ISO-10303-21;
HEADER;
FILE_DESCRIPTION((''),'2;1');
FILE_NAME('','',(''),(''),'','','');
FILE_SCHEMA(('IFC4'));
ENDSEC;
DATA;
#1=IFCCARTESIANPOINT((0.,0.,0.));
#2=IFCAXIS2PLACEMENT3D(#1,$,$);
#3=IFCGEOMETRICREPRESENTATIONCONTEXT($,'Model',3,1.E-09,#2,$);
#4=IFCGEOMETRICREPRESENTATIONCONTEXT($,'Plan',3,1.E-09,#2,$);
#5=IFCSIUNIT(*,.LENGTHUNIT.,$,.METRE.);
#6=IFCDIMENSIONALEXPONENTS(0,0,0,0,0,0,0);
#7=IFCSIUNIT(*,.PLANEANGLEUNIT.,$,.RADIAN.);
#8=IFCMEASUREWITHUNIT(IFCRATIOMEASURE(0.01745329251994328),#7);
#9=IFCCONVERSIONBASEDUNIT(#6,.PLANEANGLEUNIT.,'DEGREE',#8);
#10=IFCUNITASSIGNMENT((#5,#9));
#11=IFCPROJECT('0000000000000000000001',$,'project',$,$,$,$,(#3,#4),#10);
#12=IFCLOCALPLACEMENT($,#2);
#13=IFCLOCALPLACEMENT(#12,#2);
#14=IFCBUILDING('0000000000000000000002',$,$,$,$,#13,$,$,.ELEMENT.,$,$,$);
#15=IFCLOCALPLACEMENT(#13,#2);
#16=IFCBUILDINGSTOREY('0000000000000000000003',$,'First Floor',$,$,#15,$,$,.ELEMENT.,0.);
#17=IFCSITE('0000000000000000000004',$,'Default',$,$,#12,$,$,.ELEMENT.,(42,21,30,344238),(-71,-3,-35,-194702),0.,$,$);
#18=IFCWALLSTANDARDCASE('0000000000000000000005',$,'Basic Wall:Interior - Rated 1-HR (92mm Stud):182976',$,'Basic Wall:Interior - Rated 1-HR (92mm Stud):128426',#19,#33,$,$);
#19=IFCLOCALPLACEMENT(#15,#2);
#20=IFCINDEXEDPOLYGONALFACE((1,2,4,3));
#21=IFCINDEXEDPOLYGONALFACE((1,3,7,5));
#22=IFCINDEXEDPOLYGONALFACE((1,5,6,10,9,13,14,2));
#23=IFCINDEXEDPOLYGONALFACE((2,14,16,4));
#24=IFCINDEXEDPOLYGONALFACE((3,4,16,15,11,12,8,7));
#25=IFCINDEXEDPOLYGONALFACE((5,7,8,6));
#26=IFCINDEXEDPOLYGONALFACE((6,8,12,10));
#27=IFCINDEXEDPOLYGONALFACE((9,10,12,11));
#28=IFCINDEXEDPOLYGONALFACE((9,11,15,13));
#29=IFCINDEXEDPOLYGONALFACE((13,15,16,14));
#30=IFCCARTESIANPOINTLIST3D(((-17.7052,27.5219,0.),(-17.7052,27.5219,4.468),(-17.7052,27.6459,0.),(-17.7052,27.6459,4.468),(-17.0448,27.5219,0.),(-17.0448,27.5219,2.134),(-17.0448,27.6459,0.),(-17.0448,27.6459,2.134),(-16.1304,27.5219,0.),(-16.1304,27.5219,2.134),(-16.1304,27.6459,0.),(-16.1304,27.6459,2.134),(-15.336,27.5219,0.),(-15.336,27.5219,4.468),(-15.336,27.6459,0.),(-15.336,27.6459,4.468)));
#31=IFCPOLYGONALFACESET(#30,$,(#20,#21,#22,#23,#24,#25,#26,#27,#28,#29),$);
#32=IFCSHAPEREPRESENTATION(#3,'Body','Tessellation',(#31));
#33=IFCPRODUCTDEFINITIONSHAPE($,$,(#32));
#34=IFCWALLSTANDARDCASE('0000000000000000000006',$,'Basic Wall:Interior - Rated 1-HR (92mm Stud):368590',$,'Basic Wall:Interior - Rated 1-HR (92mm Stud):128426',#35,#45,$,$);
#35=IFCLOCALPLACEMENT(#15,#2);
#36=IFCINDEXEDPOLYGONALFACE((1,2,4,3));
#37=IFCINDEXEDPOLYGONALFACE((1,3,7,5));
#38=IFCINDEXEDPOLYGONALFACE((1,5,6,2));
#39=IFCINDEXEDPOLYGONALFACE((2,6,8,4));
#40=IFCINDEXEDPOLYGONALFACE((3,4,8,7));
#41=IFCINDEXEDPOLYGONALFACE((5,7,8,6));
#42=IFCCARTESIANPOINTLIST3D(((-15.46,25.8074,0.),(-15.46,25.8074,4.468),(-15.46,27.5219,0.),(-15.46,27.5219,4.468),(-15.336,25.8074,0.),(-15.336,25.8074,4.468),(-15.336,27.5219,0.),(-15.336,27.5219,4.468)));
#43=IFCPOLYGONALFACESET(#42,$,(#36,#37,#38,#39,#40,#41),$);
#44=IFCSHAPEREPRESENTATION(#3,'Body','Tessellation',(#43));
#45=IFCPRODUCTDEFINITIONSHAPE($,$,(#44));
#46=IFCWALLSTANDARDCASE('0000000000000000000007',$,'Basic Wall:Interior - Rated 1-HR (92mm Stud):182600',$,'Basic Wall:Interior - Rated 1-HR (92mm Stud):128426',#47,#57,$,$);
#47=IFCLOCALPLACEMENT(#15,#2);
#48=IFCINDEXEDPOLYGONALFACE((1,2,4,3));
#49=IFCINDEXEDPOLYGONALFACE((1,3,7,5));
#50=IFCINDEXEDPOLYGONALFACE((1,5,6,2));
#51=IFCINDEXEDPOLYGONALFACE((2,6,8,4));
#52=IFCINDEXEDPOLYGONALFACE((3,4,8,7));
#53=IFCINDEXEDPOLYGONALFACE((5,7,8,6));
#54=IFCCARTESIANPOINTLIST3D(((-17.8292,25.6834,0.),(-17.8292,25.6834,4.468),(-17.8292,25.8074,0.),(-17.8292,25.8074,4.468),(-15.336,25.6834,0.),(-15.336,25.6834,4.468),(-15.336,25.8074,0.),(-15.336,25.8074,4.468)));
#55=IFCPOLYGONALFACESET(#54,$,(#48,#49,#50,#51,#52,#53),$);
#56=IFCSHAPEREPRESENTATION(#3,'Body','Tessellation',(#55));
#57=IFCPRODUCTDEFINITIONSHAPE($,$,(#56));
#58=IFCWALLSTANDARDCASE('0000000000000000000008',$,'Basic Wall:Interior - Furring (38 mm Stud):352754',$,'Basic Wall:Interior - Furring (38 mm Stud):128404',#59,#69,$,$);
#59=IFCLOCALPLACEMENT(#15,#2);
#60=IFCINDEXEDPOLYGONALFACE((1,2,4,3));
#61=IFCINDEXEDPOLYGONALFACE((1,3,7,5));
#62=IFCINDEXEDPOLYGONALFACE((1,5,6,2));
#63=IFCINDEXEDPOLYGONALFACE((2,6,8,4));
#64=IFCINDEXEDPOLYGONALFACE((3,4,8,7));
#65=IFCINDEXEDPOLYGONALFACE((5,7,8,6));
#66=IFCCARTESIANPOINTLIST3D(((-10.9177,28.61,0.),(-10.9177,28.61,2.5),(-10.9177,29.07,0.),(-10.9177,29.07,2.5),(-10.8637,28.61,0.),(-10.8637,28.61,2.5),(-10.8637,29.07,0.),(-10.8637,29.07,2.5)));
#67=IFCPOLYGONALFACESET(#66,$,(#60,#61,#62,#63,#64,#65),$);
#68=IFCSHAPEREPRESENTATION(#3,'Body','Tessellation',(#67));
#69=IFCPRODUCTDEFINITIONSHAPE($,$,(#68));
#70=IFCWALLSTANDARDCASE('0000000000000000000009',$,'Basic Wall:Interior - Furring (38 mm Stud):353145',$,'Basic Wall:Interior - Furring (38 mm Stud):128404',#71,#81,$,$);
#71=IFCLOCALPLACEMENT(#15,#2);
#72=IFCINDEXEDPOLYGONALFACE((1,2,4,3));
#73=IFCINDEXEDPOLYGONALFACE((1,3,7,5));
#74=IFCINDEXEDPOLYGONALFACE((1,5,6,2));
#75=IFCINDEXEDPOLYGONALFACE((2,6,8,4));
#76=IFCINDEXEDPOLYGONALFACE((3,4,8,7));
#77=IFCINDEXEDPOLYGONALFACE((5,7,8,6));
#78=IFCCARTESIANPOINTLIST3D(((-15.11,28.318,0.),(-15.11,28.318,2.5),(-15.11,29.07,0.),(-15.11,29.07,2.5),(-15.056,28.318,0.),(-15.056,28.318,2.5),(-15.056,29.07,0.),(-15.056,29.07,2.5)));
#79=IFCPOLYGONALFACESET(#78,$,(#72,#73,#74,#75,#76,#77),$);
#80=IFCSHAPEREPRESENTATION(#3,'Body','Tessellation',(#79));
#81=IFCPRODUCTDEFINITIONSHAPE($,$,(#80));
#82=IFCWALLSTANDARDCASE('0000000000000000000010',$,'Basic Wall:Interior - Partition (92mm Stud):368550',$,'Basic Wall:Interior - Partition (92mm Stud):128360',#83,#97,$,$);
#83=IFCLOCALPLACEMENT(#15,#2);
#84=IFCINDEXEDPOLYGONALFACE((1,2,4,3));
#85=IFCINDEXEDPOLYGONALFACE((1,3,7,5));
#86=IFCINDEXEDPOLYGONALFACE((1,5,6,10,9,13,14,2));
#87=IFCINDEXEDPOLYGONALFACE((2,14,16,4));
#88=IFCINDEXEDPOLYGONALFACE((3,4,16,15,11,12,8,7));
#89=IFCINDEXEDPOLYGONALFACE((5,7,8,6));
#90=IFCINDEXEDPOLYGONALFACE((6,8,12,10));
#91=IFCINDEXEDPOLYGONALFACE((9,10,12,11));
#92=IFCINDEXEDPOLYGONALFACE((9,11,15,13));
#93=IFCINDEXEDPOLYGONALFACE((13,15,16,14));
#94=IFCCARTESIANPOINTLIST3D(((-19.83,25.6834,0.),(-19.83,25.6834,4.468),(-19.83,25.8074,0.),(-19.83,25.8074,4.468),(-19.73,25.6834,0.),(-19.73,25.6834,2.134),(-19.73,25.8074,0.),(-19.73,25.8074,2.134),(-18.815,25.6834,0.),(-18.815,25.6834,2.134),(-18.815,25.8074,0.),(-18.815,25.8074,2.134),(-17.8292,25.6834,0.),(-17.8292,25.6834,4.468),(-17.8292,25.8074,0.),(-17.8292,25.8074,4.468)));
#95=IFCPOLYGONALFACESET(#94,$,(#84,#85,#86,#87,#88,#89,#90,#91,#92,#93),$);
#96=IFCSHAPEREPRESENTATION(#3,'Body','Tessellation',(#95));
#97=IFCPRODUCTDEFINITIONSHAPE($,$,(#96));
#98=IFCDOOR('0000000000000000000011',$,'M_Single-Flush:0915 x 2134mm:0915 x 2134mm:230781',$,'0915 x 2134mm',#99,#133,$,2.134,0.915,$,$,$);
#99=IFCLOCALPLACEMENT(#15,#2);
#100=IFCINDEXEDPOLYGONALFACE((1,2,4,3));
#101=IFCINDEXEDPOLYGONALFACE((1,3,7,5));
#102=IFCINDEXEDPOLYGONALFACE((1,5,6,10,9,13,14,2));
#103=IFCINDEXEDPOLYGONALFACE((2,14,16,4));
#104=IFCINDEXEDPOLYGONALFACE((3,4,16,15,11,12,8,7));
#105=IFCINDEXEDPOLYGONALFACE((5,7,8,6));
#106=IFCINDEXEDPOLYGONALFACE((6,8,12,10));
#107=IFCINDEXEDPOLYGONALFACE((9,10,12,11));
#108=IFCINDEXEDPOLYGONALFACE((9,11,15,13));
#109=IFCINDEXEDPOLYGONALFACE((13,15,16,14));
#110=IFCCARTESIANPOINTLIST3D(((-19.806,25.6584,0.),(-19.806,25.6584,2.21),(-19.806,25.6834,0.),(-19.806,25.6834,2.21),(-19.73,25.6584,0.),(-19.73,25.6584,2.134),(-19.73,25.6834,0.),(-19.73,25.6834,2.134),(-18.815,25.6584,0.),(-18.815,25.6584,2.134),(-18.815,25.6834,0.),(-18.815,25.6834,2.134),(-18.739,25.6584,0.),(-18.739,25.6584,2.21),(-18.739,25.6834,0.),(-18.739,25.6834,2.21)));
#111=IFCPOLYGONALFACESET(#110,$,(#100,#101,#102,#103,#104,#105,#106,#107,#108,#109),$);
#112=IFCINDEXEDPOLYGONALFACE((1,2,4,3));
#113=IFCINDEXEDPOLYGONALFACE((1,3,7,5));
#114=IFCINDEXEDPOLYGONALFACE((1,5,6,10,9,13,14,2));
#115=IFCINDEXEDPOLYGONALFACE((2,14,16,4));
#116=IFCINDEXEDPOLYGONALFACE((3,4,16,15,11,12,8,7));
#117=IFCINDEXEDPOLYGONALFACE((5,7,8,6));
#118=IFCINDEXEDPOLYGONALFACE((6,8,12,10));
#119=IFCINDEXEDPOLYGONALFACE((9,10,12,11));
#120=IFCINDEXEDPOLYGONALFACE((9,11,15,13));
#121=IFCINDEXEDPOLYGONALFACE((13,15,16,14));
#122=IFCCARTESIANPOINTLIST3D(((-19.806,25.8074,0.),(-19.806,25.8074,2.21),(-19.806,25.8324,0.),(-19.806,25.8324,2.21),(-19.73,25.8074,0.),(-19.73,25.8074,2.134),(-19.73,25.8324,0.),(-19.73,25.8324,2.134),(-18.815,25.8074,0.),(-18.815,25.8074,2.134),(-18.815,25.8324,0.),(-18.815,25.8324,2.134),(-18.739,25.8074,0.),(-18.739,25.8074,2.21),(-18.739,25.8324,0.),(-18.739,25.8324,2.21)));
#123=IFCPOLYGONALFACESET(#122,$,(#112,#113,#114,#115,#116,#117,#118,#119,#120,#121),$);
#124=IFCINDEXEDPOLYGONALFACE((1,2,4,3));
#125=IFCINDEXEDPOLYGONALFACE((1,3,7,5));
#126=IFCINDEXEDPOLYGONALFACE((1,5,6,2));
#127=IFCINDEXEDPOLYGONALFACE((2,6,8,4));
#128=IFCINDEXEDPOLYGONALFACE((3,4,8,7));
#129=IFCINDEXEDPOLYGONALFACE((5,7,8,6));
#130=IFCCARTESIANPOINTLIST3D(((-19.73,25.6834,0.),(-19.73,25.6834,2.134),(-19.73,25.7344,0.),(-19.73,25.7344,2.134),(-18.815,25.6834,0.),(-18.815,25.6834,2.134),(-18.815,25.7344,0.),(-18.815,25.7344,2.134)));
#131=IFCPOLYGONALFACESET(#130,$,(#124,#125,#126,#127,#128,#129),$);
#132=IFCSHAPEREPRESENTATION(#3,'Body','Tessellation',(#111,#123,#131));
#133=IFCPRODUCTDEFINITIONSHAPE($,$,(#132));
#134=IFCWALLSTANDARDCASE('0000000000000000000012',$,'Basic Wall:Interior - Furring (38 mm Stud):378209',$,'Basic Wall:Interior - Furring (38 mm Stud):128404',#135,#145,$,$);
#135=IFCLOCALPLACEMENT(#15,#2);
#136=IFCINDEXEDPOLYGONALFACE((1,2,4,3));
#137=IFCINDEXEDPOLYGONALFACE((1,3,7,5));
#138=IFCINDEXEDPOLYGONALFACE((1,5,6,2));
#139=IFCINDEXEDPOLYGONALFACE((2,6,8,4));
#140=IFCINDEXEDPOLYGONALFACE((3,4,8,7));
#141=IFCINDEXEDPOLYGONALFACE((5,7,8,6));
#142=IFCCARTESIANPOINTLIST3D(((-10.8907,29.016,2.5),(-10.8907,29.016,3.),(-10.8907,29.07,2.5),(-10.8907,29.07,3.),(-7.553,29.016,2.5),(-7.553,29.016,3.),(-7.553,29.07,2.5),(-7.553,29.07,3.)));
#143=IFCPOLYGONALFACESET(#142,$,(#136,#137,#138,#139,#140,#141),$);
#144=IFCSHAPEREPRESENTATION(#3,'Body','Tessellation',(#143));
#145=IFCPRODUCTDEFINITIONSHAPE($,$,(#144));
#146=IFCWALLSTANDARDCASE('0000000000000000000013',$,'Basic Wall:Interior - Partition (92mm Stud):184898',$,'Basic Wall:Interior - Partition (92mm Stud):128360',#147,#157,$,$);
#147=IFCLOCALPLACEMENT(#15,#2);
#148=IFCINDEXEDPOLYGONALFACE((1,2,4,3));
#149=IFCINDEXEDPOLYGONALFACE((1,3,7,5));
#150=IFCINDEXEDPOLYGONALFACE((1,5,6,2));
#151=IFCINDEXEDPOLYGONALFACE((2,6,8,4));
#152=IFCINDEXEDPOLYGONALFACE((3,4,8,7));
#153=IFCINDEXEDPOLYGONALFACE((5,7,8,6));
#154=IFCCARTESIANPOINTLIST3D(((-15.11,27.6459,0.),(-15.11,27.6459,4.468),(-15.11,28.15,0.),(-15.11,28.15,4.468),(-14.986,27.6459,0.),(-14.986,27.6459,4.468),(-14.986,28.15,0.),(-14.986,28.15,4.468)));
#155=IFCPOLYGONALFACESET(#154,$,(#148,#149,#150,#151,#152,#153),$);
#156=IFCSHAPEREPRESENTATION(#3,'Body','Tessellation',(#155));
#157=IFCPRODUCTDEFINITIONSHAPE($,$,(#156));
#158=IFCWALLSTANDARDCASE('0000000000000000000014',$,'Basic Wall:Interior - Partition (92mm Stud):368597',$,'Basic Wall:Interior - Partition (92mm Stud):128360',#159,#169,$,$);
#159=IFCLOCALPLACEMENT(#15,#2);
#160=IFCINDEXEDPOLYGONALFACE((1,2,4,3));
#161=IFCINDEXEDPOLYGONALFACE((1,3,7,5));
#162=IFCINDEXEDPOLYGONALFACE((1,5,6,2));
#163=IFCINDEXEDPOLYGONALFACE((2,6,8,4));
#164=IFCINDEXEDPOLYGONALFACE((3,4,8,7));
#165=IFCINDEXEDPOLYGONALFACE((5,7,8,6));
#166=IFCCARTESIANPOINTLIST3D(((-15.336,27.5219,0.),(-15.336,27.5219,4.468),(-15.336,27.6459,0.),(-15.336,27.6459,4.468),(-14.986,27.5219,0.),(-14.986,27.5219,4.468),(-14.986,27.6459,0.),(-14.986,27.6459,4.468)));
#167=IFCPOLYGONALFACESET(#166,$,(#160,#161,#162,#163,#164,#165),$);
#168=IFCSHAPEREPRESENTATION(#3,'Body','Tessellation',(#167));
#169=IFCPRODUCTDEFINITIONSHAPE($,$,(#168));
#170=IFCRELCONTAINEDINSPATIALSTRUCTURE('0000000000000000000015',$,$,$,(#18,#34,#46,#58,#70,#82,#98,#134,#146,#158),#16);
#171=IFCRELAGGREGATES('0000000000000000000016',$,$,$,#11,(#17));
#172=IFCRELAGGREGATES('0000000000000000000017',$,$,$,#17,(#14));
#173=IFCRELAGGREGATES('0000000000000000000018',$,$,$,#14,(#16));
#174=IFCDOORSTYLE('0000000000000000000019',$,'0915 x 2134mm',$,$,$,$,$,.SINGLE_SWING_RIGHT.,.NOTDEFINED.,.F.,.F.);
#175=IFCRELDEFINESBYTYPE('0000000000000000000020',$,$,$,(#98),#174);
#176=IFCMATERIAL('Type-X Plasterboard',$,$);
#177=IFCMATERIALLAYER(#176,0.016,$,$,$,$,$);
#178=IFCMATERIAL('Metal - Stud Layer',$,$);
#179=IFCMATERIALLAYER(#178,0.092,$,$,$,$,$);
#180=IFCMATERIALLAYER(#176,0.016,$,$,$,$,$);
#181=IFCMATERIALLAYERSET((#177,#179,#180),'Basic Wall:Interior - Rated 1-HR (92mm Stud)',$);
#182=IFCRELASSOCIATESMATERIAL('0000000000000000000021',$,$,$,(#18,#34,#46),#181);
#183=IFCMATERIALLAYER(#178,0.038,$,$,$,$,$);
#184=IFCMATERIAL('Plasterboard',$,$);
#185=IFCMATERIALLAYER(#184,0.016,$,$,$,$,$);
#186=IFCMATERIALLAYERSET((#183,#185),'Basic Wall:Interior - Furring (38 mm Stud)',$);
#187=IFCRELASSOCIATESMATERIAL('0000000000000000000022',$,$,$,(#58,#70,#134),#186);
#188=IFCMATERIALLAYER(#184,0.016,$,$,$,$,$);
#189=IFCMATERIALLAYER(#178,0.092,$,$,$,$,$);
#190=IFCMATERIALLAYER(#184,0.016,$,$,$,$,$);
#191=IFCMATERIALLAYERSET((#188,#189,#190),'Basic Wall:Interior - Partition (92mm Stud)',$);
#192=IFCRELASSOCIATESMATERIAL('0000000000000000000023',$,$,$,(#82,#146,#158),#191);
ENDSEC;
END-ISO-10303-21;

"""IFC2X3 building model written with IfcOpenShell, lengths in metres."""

from ifc_helpers import new_model, entity, si_unit, converted_unit, frame, frame_2d, origin, origin_2d_with_axis, place, context, project, spatial, polyline, rectangle, outline, extrude, source, transform, mapped, material, layer, layer_set, layer_usage, type_object, type_shapes, element, fill, save


model = new_model("IFC2X3")

# Units and contexts
model_context = context("Model", 3, precision=1e-09, world=origin())
plan_context = context("Plan", 3, precision=1e-09, world=origin())
ifc_project = project(units=[si_unit("LENGTHUNIT", "METRE"), converted_unit("PLANEANGLEUNIT", "DEGREE", entity("IfcRatioMeasure", 0.01745329251994328), si_unit("PLANEANGLEUNIT", "RADIAN"), dimensions=[0, 0, 0, 0, 0, 0, 0])], contexts=[model_context, plan_context])

# Site, building, storey
site_placement = place(None, origin())
site = spatial("IfcSite", under=ifc_project, at=site_placement, Name="Default", CompositionType="ELEMENT", RefLatitude=(42, 21, 30, 344238), RefLongitude=(-71, -3, -35, -194702), RefElevation=0.0)
building_placement = place(site_placement, origin())
building = spatial("IfcBuilding", under=site, at=building_placement, CompositionType="ELEMENT")
storey_placement = place(building_placement, origin())
storey = spatial("IfcBuildingStorey", under=building, at=storey_placement, Name="First Floor", CompositionType="ELEMENT", Elevation=0.0)

# Wall, opening
ifc_material_1 = material(Name="Type-X Plasterboard")
ifc_layer_1 = layer(ifc_material_1, 0.016)
ifc_material_2 = material(Name="Metal - Stud Layer")
ifc_layer_2 = layer(ifc_material_2, 0.092)
ifc_layer_3 = layer(ifc_material_1, 0.016)
ifc_layer_set_1 = layer_set([ifc_layer_1, ifc_layer_2, ifc_layer_3], Name="Basic Wall:Interior - Rated 1-HR (92mm Stud)")
ifc_layer_usage_1 = layer_usage(ifc_layer_set_1, "AXIS2", "NEGATIVE", 0.062)
wall_1_placement = place(storey_placement, frame((-17.7052, 27.5839, 0.0)))
wall_1 = element("IfcWallStandardCase", 1, at=wall_1_placement, inside=storey, material=ifc_layer_usage_1, Name="Basic Wall:Interior - Rated 1-HR (92mm Stud):182976", ObjectType="Basic Wall:Interior - Rated 1-HR (92mm Stud):128426", context=model_context, shape_type="SweptSolid", body=[
    extrude(rectangle(XDim=2.3692, YDim=0.124, at=frame_2d((1.1846, 0.0), x_axis=(-1.0, 0.0))), origin(), (0.0, 0.0, 1.0), 4.468),
])
opening_1_placement = place(wall_1_placement, frame((1.1176, 0.062, 1.067)))
element("IfcOpeningElement", 2, at=opening_1_placement, cuts=wall_1, ObjectType="Opening", context=model_context, shape_type="SweptSolid", body=[
    extrude(rectangle(XDim=2.134, YDim=0.9144, at=frame_2d((0.0, 0.0), x_axis=(0.0, 1.0))), frame((0.0, 0.0, 0.0), z_axis=(0.0, -1.0, 0.0), x_axis=(1.0, 0.0, 0.0)), (0.0, 0.0, 1.0), 0.124),
])

# Walls
wall_2_placement = place(storey_placement, frame((-15.398, 25.8074, 0.0), z_axis=(0.0, 0.0, 1.0), x_axis=(0.0, 1.0, 0.0)))
element("IfcWallStandardCase", 3, at=wall_2_placement, inside=storey, material=ifc_layer_usage_1, Name="Basic Wall:Interior - Rated 1-HR (92mm Stud):368590", ObjectType="Basic Wall:Interior - Rated 1-HR (92mm Stud):128426", context=model_context, shape_type="SweptSolid", body=[
    extrude(rectangle(XDim=1.7145, YDim=0.124, at=frame_2d((0.8572, 0.0), x_axis=(-1.0, 0.0))), origin(), (0.0, 0.0, 1.0), 4.468),
])
wall_3_placement = place(storey_placement, frame((-15.336, 25.7454, 0.0), z_axis=(0.0, 0.0, 1.0), x_axis=(-1.0, 0.0, 0.0)))
element("IfcWallStandardCase", 4, at=wall_3_placement, inside=storey, material=ifc_layer_usage_1, Name="Basic Wall:Interior - Rated 1-HR (92mm Stud):182600", ObjectType="Basic Wall:Interior - Rated 1-HR (92mm Stud):128426", context=model_context, shape_type="SweptSolid", body=[
    extrude(rectangle(XDim=2.4932, YDim=0.124, at=frame_2d((1.2466, 0.0), x_axis=(-1.0, 0.0))), origin(), (0.0, 0.0, 1.0), 4.468),
])
ifc_layer_4 = layer(ifc_material_2, 0.038)
ifc_material_3 = material(Name="Plasterboard")
ifc_layer_5 = layer(ifc_material_3, 0.016)
ifc_layer_set_2 = layer_set([ifc_layer_4, ifc_layer_5], Name="Basic Wall:Interior - Furring (38 mm Stud)")
ifc_layer_usage_2 = layer_usage(ifc_layer_set_2, "AXIS2", "POSITIVE", -0.027)
wall_4_placement = place(storey_placement, frame((-10.8907, 29.07, 0.0), z_axis=(0.0, 0.0, 1.0), x_axis=(0.0, -1.0, 0.0)))
element("IfcWallStandardCase", 5, at=wall_4_placement, inside=storey, material=ifc_layer_usage_2, Name="Basic Wall:Interior - Furring (38 mm Stud):352754", ObjectType="Basic Wall:Interior - Furring (38 mm Stud):128404", context=model_context, shape_type="SweptSolid", body=[
    extrude(rectangle(XDim=0.46, YDim=0.054, at=frame_2d((0.23, 0.0), x_axis=(-1.0, 0.0))), origin(), (0.0, 0.0, 1.0), 2.5),
])
wall_5_placement = place(storey_placement, frame((-15.083, 28.318, 0.0), z_axis=(0.0, 0.0, 1.0), x_axis=(0.0, 1.0, 0.0)))
element("IfcWallStandardCase", 6, at=wall_5_placement, inside=storey, material=ifc_layer_usage_2, Name="Basic Wall:Interior - Furring (38 mm Stud):353145", ObjectType="Basic Wall:Interior - Furring (38 mm Stud):128404", context=model_context, shape_type="SweptSolid", body=[
    extrude(rectangle(XDim=0.752, YDim=0.054, at=frame_2d((0.376, 0.0), x_axis=(-1.0, 0.0))), origin(), (0.0, 0.0, 1.0), 2.5),
])

# Wall, opening, door
ifc_layer_6 = layer(ifc_material_3, 0.016)
ifc_layer_7 = layer(ifc_material_2, 0.092)
ifc_layer_8 = layer(ifc_material_3, 0.016)
ifc_layer_set_3 = layer_set([ifc_layer_6, ifc_layer_7, ifc_layer_8], Name="Basic Wall:Interior - Partition (92mm Stud)")
ifc_layer_usage_3 = layer_usage(ifc_layer_set_3, "AXIS2", "NEGATIVE", 0.062)
wall_6_placement = place(storey_placement, frame((-17.8292, 25.7454, 0.0), z_axis=(0.0, 0.0, 1.0), x_axis=(-1.0, 0.0, 0.0)))
wall_6 = element("IfcWallStandardCase", 7, at=wall_6_placement, inside=storey, material=ifc_layer_usage_3, Name="Basic Wall:Interior - Partition (92mm Stud):368550", ObjectType="Basic Wall:Interior - Partition (92mm Stud):128360", context=model_context, shape_type="SweptSolid", body=[
    extrude(rectangle(XDim=2.0008, YDim=0.124, at=frame_2d((1.0004, 0.0), x_axis=(-1.0, 0.0))), origin(), (0.0, 0.0, 1.0), 4.468),
])
opening_2_placement = place(wall_6_placement, frame((0.9858, -0.062, 0.0)))
opening_2 = element("IfcOpeningElement", 8, at=opening_2_placement, cuts=wall_6, ObjectType="Opening", context=model_context, shape_type="SweptSolid", body=[
    extrude(rectangle(XDim=0.915, YDim=2.134, at=frame_2d((1.067, 0.4575), x_axis=(0.0, 1.0))), frame((0.0, 0.0, 0.0), z_axis=(0.0, 1.0, 0.0), x_axis=(0.0, 0.0, 1.0)), (0.0, 0.0, 1.0), 0.124),
])
door_style = type_object("IfcDoorStyle", Name="0915 x 2134mm", ConstructionType="NOTDEFINED", OperationType="SINGLE_SWING_RIGHT", ParameterTakesPrecedence=False, Sizeable=False)
shared_shape_1 = source(origin(), model_context, "Body", "SweptSolid", [
    extrude(outline(polyline([(-0.5335, -1.124), (0.5335, -1.124), (0.5335, 1.086), (0.4575, 1.086), (0.4575, -1.048), (-0.4575, -1.048), (-0.4575, 1.086), (-0.5335, 1.086), (-0.5335, -1.124)])), frame((0.4575, 0.124, 1.086), z_axis=(0.0, 1.0, 0.0), x_axis=(1.0, 0.0, 0.0)), (0.0, 0.0, 1.0), 0.025),
    extrude(outline(polyline([(-1.124, -0.5335), (1.086, -0.5335), (1.086, -0.4575), (-1.048, -0.4575), (-1.048, 0.4575), (1.086, 0.4575), (1.086, 0.5335), (-1.124, 0.5335), (-1.124, -0.5335)])), frame((0.4575, -0.025, 1.086), z_axis=(0.0, 1.0, 0.0), x_axis=(0.0, 0.0, -1.0)), (0.0, 0.0, 1.0), 0.025),
    extrude(rectangle(XDim=0.051, YDim=0.915, at=origin_2d_with_axis()), frame((0.4575, 0.0985, 0.0), z_axis=(0.0, 0.0, 1.0), x_axis=(0.0, 1.0, 0.0)), (0.0, 0.0, 1.0), 2.134),
])
type_shapes(door_style, [shared_shape_1])
door_placement = place(opening_2_placement, origin())
door = element("IfcDoor", 9, at=door_placement, inside=storey, type_object=door_style, Name="M_Single-Flush:0915 x 2134mm:0915 x 2134mm:230781", ObjectType="0915 x 2134mm", OverallHeight=2.134, OverallWidth=0.915, context=model_context, shape_type="MappedRepresentation", body=[
    mapped(shared_shape_1, transform((0.0, 0.0, 0.0), scale=1.0)),
])
fill(opening_2, door)

# Walls
wall_7_placement = place(storey_placement, frame((-10.8907, 29.043, 2.5)))
element("IfcWallStandardCase", 10, at=wall_7_placement, inside=storey, material=ifc_layer_usage_2, Name="Basic Wall:Interior - Furring (38 mm Stud):378209", ObjectType="Basic Wall:Interior - Furring (38 mm Stud):128404", context=model_context, shape_type="SweptSolid", body=[
    extrude(rectangle(XDim=3.3377, YDim=0.054, at=frame_2d((1.6689, 0.0), x_axis=(-1.0, 0.0))), origin(), (0.0, 0.0, 1.0), 0.5),
])
wall_8_placement = place(storey_placement, frame((-15.048, 27.6459, 0.0), z_axis=(0.0, 0.0, 1.0), x_axis=(0.0, 1.0, 0.0)))
element("IfcWallStandardCase", 11, at=wall_8_placement, inside=storey, material=ifc_layer_usage_3, Name="Basic Wall:Interior - Partition (92mm Stud):184898", ObjectType="Basic Wall:Interior - Partition (92mm Stud):128360", context=model_context, shape_type="SweptSolid", body=[
    extrude(rectangle(XDim=0.5041, YDim=0.124, at=frame_2d((0.2521, 0.0), x_axis=(-1.0, 0.0))), origin(), (0.0, 0.0, 1.0), 4.468),
])
wall_9_placement = place(storey_placement, frame((-15.336, 27.5839, 0.0)))
element("IfcWallStandardCase", 12, at=wall_9_placement, inside=storey, material=ifc_layer_usage_3, Name="Basic Wall:Interior - Partition (92mm Stud):368597", ObjectType="Basic Wall:Interior - Partition (92mm Stud):128360", context=model_context, shape_type="SweptSolid", body=[
    extrude(rectangle(XDim=0.35, YDim=0.124, at=frame_2d((0.175, 0.0), x_axis=(-1.0, 0.0))), origin(), (0.0, 0.0, 1.0), 4.468),
])

save(model, "model.ifc")
